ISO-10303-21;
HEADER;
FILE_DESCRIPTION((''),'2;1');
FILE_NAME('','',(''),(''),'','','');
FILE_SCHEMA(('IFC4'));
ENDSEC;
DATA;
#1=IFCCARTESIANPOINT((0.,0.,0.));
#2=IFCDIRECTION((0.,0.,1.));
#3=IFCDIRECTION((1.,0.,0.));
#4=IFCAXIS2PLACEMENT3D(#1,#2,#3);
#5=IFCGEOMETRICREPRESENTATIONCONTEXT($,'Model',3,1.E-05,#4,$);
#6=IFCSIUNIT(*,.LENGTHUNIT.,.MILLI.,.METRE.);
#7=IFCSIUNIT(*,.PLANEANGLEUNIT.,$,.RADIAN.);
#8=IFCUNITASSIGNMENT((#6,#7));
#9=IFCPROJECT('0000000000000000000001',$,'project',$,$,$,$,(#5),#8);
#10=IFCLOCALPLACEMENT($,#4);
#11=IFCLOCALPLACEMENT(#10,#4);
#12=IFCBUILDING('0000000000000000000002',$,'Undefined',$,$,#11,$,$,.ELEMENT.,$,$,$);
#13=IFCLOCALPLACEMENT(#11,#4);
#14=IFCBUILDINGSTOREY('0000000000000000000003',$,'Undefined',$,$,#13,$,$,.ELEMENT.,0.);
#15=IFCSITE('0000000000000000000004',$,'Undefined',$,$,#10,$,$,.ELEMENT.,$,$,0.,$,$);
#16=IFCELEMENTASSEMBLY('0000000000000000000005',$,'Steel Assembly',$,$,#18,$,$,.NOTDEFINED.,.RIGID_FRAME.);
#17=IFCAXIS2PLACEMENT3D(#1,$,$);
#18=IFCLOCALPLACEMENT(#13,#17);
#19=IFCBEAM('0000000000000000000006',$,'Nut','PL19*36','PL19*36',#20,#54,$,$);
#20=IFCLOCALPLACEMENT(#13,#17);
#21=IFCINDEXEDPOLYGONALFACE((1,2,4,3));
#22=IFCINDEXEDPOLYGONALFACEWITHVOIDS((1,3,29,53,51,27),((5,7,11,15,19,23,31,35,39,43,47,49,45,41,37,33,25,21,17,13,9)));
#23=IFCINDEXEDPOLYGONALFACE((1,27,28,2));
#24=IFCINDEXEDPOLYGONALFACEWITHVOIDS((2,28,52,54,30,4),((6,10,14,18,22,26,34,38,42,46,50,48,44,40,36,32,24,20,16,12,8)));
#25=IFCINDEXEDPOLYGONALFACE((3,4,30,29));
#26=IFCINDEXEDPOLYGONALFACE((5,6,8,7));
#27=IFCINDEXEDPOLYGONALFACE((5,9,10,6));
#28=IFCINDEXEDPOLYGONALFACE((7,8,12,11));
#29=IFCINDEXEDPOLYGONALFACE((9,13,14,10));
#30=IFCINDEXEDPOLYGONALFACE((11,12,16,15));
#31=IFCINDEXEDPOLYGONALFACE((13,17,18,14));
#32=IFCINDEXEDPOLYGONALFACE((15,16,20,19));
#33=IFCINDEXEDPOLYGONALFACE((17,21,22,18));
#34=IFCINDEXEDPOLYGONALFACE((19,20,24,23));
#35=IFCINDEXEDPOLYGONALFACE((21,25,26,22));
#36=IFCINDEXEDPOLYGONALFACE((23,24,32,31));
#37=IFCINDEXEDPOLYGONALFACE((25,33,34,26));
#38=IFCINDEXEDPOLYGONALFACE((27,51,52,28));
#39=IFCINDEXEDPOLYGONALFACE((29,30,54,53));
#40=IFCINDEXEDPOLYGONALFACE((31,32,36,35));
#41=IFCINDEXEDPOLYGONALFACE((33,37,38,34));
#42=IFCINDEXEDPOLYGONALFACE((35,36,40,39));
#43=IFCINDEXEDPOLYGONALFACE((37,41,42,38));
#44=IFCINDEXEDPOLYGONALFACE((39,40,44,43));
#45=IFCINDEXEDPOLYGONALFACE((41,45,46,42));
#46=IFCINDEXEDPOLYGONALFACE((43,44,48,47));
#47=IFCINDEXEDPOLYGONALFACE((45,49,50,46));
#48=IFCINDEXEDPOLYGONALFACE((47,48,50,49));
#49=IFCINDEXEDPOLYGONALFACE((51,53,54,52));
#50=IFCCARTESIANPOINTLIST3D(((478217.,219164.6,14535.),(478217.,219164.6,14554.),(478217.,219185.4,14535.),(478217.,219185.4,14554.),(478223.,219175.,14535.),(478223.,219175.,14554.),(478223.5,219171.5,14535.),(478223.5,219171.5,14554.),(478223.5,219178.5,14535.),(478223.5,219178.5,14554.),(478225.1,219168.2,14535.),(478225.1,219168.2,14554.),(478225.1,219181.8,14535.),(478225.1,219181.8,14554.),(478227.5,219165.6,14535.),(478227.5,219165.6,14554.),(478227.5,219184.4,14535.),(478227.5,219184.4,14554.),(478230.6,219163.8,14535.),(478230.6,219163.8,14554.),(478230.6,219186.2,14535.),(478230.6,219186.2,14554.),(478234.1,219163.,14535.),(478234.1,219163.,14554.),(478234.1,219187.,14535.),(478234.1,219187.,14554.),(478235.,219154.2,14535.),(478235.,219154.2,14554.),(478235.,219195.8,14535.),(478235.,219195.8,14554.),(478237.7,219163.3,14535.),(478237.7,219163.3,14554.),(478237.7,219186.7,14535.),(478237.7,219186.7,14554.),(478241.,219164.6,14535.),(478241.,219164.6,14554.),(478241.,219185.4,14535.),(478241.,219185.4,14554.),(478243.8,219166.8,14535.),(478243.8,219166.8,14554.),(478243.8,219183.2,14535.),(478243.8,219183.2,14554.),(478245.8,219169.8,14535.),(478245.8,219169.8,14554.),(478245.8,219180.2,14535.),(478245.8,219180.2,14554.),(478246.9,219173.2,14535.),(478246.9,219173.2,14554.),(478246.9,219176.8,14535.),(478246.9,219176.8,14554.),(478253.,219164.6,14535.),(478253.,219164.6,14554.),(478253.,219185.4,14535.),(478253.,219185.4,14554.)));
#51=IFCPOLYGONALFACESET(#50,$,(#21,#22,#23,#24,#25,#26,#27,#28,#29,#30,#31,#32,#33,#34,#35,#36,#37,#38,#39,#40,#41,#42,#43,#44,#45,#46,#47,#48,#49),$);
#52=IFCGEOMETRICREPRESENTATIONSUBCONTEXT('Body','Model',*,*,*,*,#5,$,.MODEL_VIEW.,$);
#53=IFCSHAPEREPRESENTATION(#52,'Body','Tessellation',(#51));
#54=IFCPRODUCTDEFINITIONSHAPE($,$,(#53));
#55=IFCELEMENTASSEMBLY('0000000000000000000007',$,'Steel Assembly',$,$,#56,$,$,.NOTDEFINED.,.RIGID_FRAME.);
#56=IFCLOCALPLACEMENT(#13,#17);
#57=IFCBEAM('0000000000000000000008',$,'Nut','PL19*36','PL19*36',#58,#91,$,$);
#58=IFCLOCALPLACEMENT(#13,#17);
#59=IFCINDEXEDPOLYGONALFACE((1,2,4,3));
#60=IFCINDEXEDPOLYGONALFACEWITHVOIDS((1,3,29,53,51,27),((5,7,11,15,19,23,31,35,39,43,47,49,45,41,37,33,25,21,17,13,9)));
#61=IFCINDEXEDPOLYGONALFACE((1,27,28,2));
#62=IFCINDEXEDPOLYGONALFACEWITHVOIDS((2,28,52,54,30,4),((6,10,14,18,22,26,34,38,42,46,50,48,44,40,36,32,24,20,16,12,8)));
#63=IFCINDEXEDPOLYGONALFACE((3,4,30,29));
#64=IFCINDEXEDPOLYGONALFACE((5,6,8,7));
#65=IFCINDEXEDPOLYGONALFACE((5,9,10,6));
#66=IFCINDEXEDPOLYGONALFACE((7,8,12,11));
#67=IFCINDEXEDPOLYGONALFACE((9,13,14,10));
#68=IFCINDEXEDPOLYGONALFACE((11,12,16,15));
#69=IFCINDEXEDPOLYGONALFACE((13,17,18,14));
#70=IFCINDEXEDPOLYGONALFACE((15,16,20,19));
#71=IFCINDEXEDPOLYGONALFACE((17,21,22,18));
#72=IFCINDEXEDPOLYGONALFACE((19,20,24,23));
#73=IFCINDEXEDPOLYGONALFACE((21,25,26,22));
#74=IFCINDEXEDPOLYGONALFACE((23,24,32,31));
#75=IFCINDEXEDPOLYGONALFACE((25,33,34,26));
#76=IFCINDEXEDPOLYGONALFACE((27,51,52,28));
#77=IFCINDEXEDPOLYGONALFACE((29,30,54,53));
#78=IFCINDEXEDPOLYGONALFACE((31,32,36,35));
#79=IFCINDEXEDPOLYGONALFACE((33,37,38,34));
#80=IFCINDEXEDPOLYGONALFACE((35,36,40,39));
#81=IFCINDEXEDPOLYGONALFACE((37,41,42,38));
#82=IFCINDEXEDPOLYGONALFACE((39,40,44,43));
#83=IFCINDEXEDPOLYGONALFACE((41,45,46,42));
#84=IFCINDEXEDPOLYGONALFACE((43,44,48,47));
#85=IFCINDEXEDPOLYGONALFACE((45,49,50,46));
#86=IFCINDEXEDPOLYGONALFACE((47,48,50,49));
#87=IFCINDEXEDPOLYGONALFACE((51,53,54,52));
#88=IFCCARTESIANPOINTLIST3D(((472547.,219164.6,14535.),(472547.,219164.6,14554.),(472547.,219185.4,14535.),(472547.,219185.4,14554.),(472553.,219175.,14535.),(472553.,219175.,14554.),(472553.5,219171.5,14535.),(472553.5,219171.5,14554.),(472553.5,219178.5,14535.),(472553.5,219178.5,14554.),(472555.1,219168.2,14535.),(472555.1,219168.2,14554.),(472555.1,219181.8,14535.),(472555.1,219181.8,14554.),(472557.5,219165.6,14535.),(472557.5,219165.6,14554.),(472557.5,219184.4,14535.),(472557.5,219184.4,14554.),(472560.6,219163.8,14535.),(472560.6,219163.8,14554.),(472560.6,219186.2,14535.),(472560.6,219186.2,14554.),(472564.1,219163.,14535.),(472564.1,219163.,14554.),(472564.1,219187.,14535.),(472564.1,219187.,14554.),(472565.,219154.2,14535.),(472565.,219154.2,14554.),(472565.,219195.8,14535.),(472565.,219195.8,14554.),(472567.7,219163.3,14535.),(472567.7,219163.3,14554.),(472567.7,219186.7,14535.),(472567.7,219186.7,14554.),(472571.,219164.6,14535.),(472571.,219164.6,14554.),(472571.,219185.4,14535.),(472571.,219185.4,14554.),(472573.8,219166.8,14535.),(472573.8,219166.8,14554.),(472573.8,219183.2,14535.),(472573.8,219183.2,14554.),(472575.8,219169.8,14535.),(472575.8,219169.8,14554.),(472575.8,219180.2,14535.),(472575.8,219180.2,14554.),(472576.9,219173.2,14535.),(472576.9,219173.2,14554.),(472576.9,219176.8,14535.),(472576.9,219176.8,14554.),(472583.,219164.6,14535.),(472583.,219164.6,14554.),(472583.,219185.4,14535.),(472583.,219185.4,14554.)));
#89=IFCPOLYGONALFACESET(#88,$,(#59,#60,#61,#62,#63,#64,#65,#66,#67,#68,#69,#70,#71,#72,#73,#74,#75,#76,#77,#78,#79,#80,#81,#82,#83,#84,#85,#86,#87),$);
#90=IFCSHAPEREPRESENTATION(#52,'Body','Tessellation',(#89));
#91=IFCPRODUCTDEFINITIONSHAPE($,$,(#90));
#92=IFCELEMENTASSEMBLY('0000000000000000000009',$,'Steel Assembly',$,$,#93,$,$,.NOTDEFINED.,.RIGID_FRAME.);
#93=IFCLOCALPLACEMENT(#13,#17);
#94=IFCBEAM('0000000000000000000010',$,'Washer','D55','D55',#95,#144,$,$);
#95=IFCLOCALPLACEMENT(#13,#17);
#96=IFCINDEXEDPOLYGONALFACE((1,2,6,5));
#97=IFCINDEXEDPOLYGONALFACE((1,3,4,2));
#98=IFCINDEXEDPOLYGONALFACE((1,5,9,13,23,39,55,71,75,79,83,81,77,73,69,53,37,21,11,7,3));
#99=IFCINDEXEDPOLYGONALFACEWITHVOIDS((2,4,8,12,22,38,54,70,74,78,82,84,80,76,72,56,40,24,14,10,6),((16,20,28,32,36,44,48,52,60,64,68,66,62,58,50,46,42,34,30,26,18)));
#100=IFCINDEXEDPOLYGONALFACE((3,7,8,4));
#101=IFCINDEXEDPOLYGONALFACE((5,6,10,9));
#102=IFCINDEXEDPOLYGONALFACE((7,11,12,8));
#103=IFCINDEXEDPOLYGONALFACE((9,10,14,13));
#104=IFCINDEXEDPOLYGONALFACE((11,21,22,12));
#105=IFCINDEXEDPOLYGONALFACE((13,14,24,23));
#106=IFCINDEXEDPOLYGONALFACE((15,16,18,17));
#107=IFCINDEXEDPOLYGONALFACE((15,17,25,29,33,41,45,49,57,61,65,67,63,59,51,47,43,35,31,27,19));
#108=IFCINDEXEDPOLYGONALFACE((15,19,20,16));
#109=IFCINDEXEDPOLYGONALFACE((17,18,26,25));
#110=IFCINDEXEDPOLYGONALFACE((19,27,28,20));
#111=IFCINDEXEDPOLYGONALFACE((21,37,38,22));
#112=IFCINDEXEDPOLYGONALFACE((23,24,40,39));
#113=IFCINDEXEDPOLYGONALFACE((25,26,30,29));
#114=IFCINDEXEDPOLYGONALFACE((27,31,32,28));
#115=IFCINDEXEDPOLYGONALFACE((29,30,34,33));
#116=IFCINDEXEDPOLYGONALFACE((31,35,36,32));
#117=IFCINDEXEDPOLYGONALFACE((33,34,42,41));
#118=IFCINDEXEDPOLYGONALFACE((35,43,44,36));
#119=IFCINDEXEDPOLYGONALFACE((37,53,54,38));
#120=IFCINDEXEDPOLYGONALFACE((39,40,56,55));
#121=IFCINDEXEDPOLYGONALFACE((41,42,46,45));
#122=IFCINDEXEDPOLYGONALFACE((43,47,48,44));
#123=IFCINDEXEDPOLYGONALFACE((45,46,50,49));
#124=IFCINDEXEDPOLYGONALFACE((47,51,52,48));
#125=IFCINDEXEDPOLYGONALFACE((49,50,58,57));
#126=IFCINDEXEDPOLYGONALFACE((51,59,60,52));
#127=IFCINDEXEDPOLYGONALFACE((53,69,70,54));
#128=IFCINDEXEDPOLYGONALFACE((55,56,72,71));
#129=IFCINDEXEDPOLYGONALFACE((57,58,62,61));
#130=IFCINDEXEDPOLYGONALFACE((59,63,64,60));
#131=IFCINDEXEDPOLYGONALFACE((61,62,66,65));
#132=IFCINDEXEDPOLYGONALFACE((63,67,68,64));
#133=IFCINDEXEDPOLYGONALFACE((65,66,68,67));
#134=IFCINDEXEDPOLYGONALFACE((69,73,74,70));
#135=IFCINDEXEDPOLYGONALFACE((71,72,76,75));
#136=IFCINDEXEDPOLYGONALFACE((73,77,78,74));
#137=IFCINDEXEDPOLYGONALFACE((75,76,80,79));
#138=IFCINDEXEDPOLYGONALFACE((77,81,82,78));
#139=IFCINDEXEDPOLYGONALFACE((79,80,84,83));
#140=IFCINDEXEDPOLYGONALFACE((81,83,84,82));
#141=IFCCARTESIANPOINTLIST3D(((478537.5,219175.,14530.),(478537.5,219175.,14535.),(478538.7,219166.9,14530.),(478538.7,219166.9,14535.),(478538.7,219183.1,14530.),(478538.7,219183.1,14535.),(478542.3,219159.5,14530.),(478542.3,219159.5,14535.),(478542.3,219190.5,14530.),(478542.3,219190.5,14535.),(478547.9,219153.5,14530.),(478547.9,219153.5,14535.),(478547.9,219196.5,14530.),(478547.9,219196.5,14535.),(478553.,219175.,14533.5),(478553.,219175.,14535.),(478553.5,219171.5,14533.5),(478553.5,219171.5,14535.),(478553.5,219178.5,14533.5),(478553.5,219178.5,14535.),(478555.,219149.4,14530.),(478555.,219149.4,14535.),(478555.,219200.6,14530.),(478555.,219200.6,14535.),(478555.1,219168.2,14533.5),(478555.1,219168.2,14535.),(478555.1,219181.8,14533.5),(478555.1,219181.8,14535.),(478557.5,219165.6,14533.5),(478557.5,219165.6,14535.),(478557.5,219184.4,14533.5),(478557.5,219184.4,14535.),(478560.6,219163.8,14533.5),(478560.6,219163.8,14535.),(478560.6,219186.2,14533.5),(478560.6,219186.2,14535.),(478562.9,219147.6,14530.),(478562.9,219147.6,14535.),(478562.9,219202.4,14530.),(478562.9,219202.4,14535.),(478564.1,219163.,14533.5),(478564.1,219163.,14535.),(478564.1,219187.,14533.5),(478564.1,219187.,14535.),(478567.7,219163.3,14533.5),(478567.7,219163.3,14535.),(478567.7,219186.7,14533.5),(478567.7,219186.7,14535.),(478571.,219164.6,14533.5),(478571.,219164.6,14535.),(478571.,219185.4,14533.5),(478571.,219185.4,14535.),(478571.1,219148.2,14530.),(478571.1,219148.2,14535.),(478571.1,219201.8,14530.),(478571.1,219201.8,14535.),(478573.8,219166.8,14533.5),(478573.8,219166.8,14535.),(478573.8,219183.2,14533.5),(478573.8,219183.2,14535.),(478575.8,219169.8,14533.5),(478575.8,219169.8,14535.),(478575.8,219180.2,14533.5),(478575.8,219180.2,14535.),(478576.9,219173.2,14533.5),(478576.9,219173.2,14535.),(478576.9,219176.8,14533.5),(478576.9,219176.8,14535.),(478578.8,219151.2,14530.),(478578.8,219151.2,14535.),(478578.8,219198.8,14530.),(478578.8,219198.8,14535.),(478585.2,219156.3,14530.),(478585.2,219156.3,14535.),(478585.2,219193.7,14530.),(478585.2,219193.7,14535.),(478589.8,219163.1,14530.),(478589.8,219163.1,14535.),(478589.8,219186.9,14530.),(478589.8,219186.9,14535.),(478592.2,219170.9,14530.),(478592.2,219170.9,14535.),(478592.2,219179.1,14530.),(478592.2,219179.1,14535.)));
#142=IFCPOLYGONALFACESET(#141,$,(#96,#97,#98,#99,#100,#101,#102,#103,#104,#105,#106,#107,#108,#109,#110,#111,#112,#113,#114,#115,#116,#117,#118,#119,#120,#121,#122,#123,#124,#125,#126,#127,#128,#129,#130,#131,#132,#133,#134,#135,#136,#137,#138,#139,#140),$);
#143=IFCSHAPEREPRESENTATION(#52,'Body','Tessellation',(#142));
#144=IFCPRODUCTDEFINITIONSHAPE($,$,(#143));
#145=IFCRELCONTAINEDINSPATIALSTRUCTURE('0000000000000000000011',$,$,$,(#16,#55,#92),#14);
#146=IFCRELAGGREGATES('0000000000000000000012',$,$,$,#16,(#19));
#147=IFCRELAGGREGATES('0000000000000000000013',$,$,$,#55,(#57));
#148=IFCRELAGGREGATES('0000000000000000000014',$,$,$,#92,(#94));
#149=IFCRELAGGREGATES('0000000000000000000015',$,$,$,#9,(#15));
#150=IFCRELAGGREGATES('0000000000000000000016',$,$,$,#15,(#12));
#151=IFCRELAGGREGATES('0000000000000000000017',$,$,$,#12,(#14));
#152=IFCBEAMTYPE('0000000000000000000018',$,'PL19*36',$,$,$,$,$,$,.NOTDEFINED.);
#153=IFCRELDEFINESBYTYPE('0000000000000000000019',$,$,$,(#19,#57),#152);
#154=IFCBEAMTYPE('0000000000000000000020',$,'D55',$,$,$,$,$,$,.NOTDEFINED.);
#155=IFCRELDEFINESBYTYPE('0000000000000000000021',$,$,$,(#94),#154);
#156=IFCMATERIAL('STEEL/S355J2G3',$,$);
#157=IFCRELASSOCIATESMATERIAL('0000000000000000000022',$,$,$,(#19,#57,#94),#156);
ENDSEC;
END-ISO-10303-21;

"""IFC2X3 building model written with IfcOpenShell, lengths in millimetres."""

from ifc_helpers import new_model, si_unit, frame, origin_with_axes, origin_2d_with_axis, place, context, subcontext, project, spatial, rectangle, circle, extrude, boolean, halfspace, material, type_object, element, aggregate, save


model = new_model("IFC2X3")

# Units and contexts
model_context = context("Model", 3, precision=1e-05, world=origin_with_axes())
body_context = subcontext(model_context, "Body", "Model", "MODEL_VIEW")
ifc_project = project(units=[si_unit("LENGTHUNIT", "METRE", prefix="MILLI"), si_unit("PLANEANGLEUNIT", "RADIAN")], contexts=[model_context])

# Site, building, storey
site_placement = place(None, origin_with_axes())
site = spatial("IfcSite", under=ifc_project, at=site_placement, Name="Undefined", CompositionType="ELEMENT", RefElevation=0.0)
building_placement = place(site_placement, origin_with_axes())
building = spatial("IfcBuilding", under=site, at=building_placement, Name="Undefined", CompositionType="ELEMENT")
storey_placement = place(building_placement, origin_with_axes())
storey = spatial("IfcBuildingStorey", under=building, at=storey_placement, Name="Undefined", CompositionType="ELEMENT", Elevation=0.0)

# Element assemblies, beams
ifc_material_1 = material(Name="STEEL/S355J2G3")
beam_type_1 = type_object("IfcBeamType", Name="PL19*36", PredefinedType="NOTDEFINED")
assembly_1_placement = place(storey_placement, origin_with_axes())
assembly_1 = element("IfcElementAssembly", 1, at=assembly_1_placement, inside=storey, Name="Steel Assembly", AssemblyPlace="NOTDEFINED", PredefinedType="RIGID_FRAME")
beam_1_placement = place(assembly_1_placement, frame((478235.0, 219195.8, 14544.5), z_axis=(-1.0, 0.0, 0.0), x_axis=(0.0, -1.0, 0.0)))
beam_1 = element("IfcBeam", 2, at=beam_1_placement, type_object=beam_type_1, material=ifc_material_1, Name="Nut", Description="PL19*36", ObjectType="PL19*36", context=body_context, shape_type="CSG", body=[
    boolean("DIFFERENCE", boolean("DIFFERENCE", boolean("DIFFERENCE", boolean("DIFFERENCE", boolean("DIFFERENCE", extrude(rectangle(XDim=19.0, YDim=36.0, at=origin_2d_with_axis()), frame((41.6, 0.0, 0.0), z_axis=(-1.0, 0.0, 0.0), x_axis=(0.0, -1.0, 0.0)), (0.0, 0.0, 1.0), 41.6), extrude(circle(Radius=12.0, at=origin_2d_with_axis()), frame((20.8, -9.5, 0.0), z_axis=(0.0, 1.0, 0.0), x_axis=(0.0, 0.0, 1.0)), (0.0, 0.0, 1.0), 19.0)), halfspace(frame((31.2, -9.5, -18.0), z_axis=(0.865865, 0.0, -0.500278), x_axis=(0.500278, 0.0, 0.865865)), False)), halfspace(frame((52.0, -9.5, -18.0), z_axis=(0.865865, 0.0, 0.500278), x_axis=(-0.500278, 0.0, 0.865865)), False)), halfspace(frame((-10.4, 9.5, -18.0), z_axis=(-0.865865, 0.0, 0.500278), x_axis=(0.500278, 0.0, 0.865865)), False)), halfspace(frame((10.4, 9.5, -18.0), z_axis=(-0.865865, 0.0, -0.500278), x_axis=(-0.500278, 0.0, 0.865865)), False)),
])
aggregate(assembly_1, [beam_1])
assembly_2_placement = place(storey_placement, origin_with_axes())
assembly_2 = element("IfcElementAssembly", 3, at=assembly_2_placement, inside=storey, Name="Steel Assembly", AssemblyPlace="NOTDEFINED", PredefinedType="RIGID_FRAME")
beam_2_placement = place(assembly_2_placement, frame((472565.0, 219195.8, 14544.5), z_axis=(-1.0, 0.0, 0.0), x_axis=(0.0, -1.0, 0.0)))
beam_2 = element("IfcBeam", 4, at=beam_2_placement, type_object=beam_type_1, material=ifc_material_1, Name="Nut", Description="PL19*36", ObjectType="PL19*36", context=body_context, shape_type="CSG", body=[
    boolean("DIFFERENCE", boolean("DIFFERENCE", boolean("DIFFERENCE", boolean("DIFFERENCE", boolean("DIFFERENCE", extrude(rectangle(XDim=19.0, YDim=36.0, at=origin_2d_with_axis()), frame((41.6, 0.0, 0.0), z_axis=(-1.0, 0.0, 0.0), x_axis=(0.0, -1.0, 0.0)), (0.0, 0.0, 1.0), 41.6), extrude(circle(Radius=12.0, at=origin_2d_with_axis()), frame((20.8, -9.5, 0.0), z_axis=(0.0, 1.0, 0.0), x_axis=(0.0, 0.0, 1.0)), (0.0, 0.0, 1.0), 19.0)), halfspace(frame((31.2, -9.5, -18.0), z_axis=(0.865865, 0.0, -0.500278), x_axis=(0.500278, 0.0, 0.865865)), False)), halfspace(frame((52.0, -9.5, -18.0), z_axis=(0.865865, 0.0, 0.500278), x_axis=(-0.500278, 0.0, 0.865865)), False)), halfspace(frame((-10.4, 9.5, -18.0), z_axis=(-0.865865, 0.0, 0.500278), x_axis=(0.500278, 0.0, 0.865865)), False)), halfspace(frame((10.4, 9.5, -18.0), z_axis=(-0.865865, 0.0, -0.500278), x_axis=(-0.500278, 0.0, 0.865865)), False)),
])
aggregate(assembly_2, [beam_2])
assembly_3_placement = place(storey_placement, origin_with_axes())
assembly_3 = element("IfcElementAssembly", 5, at=assembly_3_placement, inside=storey, Name="Steel Assembly", AssemblyPlace="NOTDEFINED", PredefinedType="RIGID_FRAME")
beam_type_2 = type_object("IfcBeamType", Name="D55", PredefinedType="NOTDEFINED")
beam_3_placement = place(assembly_3_placement, frame((478565.0, 219175.0, 14535.0), z_axis=(0.0, -1.0, 0.0), x_axis=(0.0, 0.0, -1.0)))
beam_3 = element("IfcBeam", 6, at=beam_3_placement, type_object=beam_type_2, material=ifc_material_1, Name="Washer", Description="D55", ObjectType="D55", context=body_context, shape_type="CSG", body=[
    boolean("DIFFERENCE", extrude(circle(Radius=27.5, at=origin_2d_with_axis()), frame((5.0, 0.0, 0.0), z_axis=(-1.0, 0.0, 0.0), x_axis=(0.0, -1.0, 0.0)), (0.0, 0.0, 1.0), 5.0), extrude(circle(Radius=12.0, at=origin_2d_with_axis()), frame((1.5, 0.0, 0.0), z_axis=(-1.0, 0.0, 0.0), x_axis=(0.0, -1.0, 0.0)), (0.0, 0.0, 1.0), 10.0)),
])
aggregate(assembly_3, [beam_3])

save(model, "model.ifc")
